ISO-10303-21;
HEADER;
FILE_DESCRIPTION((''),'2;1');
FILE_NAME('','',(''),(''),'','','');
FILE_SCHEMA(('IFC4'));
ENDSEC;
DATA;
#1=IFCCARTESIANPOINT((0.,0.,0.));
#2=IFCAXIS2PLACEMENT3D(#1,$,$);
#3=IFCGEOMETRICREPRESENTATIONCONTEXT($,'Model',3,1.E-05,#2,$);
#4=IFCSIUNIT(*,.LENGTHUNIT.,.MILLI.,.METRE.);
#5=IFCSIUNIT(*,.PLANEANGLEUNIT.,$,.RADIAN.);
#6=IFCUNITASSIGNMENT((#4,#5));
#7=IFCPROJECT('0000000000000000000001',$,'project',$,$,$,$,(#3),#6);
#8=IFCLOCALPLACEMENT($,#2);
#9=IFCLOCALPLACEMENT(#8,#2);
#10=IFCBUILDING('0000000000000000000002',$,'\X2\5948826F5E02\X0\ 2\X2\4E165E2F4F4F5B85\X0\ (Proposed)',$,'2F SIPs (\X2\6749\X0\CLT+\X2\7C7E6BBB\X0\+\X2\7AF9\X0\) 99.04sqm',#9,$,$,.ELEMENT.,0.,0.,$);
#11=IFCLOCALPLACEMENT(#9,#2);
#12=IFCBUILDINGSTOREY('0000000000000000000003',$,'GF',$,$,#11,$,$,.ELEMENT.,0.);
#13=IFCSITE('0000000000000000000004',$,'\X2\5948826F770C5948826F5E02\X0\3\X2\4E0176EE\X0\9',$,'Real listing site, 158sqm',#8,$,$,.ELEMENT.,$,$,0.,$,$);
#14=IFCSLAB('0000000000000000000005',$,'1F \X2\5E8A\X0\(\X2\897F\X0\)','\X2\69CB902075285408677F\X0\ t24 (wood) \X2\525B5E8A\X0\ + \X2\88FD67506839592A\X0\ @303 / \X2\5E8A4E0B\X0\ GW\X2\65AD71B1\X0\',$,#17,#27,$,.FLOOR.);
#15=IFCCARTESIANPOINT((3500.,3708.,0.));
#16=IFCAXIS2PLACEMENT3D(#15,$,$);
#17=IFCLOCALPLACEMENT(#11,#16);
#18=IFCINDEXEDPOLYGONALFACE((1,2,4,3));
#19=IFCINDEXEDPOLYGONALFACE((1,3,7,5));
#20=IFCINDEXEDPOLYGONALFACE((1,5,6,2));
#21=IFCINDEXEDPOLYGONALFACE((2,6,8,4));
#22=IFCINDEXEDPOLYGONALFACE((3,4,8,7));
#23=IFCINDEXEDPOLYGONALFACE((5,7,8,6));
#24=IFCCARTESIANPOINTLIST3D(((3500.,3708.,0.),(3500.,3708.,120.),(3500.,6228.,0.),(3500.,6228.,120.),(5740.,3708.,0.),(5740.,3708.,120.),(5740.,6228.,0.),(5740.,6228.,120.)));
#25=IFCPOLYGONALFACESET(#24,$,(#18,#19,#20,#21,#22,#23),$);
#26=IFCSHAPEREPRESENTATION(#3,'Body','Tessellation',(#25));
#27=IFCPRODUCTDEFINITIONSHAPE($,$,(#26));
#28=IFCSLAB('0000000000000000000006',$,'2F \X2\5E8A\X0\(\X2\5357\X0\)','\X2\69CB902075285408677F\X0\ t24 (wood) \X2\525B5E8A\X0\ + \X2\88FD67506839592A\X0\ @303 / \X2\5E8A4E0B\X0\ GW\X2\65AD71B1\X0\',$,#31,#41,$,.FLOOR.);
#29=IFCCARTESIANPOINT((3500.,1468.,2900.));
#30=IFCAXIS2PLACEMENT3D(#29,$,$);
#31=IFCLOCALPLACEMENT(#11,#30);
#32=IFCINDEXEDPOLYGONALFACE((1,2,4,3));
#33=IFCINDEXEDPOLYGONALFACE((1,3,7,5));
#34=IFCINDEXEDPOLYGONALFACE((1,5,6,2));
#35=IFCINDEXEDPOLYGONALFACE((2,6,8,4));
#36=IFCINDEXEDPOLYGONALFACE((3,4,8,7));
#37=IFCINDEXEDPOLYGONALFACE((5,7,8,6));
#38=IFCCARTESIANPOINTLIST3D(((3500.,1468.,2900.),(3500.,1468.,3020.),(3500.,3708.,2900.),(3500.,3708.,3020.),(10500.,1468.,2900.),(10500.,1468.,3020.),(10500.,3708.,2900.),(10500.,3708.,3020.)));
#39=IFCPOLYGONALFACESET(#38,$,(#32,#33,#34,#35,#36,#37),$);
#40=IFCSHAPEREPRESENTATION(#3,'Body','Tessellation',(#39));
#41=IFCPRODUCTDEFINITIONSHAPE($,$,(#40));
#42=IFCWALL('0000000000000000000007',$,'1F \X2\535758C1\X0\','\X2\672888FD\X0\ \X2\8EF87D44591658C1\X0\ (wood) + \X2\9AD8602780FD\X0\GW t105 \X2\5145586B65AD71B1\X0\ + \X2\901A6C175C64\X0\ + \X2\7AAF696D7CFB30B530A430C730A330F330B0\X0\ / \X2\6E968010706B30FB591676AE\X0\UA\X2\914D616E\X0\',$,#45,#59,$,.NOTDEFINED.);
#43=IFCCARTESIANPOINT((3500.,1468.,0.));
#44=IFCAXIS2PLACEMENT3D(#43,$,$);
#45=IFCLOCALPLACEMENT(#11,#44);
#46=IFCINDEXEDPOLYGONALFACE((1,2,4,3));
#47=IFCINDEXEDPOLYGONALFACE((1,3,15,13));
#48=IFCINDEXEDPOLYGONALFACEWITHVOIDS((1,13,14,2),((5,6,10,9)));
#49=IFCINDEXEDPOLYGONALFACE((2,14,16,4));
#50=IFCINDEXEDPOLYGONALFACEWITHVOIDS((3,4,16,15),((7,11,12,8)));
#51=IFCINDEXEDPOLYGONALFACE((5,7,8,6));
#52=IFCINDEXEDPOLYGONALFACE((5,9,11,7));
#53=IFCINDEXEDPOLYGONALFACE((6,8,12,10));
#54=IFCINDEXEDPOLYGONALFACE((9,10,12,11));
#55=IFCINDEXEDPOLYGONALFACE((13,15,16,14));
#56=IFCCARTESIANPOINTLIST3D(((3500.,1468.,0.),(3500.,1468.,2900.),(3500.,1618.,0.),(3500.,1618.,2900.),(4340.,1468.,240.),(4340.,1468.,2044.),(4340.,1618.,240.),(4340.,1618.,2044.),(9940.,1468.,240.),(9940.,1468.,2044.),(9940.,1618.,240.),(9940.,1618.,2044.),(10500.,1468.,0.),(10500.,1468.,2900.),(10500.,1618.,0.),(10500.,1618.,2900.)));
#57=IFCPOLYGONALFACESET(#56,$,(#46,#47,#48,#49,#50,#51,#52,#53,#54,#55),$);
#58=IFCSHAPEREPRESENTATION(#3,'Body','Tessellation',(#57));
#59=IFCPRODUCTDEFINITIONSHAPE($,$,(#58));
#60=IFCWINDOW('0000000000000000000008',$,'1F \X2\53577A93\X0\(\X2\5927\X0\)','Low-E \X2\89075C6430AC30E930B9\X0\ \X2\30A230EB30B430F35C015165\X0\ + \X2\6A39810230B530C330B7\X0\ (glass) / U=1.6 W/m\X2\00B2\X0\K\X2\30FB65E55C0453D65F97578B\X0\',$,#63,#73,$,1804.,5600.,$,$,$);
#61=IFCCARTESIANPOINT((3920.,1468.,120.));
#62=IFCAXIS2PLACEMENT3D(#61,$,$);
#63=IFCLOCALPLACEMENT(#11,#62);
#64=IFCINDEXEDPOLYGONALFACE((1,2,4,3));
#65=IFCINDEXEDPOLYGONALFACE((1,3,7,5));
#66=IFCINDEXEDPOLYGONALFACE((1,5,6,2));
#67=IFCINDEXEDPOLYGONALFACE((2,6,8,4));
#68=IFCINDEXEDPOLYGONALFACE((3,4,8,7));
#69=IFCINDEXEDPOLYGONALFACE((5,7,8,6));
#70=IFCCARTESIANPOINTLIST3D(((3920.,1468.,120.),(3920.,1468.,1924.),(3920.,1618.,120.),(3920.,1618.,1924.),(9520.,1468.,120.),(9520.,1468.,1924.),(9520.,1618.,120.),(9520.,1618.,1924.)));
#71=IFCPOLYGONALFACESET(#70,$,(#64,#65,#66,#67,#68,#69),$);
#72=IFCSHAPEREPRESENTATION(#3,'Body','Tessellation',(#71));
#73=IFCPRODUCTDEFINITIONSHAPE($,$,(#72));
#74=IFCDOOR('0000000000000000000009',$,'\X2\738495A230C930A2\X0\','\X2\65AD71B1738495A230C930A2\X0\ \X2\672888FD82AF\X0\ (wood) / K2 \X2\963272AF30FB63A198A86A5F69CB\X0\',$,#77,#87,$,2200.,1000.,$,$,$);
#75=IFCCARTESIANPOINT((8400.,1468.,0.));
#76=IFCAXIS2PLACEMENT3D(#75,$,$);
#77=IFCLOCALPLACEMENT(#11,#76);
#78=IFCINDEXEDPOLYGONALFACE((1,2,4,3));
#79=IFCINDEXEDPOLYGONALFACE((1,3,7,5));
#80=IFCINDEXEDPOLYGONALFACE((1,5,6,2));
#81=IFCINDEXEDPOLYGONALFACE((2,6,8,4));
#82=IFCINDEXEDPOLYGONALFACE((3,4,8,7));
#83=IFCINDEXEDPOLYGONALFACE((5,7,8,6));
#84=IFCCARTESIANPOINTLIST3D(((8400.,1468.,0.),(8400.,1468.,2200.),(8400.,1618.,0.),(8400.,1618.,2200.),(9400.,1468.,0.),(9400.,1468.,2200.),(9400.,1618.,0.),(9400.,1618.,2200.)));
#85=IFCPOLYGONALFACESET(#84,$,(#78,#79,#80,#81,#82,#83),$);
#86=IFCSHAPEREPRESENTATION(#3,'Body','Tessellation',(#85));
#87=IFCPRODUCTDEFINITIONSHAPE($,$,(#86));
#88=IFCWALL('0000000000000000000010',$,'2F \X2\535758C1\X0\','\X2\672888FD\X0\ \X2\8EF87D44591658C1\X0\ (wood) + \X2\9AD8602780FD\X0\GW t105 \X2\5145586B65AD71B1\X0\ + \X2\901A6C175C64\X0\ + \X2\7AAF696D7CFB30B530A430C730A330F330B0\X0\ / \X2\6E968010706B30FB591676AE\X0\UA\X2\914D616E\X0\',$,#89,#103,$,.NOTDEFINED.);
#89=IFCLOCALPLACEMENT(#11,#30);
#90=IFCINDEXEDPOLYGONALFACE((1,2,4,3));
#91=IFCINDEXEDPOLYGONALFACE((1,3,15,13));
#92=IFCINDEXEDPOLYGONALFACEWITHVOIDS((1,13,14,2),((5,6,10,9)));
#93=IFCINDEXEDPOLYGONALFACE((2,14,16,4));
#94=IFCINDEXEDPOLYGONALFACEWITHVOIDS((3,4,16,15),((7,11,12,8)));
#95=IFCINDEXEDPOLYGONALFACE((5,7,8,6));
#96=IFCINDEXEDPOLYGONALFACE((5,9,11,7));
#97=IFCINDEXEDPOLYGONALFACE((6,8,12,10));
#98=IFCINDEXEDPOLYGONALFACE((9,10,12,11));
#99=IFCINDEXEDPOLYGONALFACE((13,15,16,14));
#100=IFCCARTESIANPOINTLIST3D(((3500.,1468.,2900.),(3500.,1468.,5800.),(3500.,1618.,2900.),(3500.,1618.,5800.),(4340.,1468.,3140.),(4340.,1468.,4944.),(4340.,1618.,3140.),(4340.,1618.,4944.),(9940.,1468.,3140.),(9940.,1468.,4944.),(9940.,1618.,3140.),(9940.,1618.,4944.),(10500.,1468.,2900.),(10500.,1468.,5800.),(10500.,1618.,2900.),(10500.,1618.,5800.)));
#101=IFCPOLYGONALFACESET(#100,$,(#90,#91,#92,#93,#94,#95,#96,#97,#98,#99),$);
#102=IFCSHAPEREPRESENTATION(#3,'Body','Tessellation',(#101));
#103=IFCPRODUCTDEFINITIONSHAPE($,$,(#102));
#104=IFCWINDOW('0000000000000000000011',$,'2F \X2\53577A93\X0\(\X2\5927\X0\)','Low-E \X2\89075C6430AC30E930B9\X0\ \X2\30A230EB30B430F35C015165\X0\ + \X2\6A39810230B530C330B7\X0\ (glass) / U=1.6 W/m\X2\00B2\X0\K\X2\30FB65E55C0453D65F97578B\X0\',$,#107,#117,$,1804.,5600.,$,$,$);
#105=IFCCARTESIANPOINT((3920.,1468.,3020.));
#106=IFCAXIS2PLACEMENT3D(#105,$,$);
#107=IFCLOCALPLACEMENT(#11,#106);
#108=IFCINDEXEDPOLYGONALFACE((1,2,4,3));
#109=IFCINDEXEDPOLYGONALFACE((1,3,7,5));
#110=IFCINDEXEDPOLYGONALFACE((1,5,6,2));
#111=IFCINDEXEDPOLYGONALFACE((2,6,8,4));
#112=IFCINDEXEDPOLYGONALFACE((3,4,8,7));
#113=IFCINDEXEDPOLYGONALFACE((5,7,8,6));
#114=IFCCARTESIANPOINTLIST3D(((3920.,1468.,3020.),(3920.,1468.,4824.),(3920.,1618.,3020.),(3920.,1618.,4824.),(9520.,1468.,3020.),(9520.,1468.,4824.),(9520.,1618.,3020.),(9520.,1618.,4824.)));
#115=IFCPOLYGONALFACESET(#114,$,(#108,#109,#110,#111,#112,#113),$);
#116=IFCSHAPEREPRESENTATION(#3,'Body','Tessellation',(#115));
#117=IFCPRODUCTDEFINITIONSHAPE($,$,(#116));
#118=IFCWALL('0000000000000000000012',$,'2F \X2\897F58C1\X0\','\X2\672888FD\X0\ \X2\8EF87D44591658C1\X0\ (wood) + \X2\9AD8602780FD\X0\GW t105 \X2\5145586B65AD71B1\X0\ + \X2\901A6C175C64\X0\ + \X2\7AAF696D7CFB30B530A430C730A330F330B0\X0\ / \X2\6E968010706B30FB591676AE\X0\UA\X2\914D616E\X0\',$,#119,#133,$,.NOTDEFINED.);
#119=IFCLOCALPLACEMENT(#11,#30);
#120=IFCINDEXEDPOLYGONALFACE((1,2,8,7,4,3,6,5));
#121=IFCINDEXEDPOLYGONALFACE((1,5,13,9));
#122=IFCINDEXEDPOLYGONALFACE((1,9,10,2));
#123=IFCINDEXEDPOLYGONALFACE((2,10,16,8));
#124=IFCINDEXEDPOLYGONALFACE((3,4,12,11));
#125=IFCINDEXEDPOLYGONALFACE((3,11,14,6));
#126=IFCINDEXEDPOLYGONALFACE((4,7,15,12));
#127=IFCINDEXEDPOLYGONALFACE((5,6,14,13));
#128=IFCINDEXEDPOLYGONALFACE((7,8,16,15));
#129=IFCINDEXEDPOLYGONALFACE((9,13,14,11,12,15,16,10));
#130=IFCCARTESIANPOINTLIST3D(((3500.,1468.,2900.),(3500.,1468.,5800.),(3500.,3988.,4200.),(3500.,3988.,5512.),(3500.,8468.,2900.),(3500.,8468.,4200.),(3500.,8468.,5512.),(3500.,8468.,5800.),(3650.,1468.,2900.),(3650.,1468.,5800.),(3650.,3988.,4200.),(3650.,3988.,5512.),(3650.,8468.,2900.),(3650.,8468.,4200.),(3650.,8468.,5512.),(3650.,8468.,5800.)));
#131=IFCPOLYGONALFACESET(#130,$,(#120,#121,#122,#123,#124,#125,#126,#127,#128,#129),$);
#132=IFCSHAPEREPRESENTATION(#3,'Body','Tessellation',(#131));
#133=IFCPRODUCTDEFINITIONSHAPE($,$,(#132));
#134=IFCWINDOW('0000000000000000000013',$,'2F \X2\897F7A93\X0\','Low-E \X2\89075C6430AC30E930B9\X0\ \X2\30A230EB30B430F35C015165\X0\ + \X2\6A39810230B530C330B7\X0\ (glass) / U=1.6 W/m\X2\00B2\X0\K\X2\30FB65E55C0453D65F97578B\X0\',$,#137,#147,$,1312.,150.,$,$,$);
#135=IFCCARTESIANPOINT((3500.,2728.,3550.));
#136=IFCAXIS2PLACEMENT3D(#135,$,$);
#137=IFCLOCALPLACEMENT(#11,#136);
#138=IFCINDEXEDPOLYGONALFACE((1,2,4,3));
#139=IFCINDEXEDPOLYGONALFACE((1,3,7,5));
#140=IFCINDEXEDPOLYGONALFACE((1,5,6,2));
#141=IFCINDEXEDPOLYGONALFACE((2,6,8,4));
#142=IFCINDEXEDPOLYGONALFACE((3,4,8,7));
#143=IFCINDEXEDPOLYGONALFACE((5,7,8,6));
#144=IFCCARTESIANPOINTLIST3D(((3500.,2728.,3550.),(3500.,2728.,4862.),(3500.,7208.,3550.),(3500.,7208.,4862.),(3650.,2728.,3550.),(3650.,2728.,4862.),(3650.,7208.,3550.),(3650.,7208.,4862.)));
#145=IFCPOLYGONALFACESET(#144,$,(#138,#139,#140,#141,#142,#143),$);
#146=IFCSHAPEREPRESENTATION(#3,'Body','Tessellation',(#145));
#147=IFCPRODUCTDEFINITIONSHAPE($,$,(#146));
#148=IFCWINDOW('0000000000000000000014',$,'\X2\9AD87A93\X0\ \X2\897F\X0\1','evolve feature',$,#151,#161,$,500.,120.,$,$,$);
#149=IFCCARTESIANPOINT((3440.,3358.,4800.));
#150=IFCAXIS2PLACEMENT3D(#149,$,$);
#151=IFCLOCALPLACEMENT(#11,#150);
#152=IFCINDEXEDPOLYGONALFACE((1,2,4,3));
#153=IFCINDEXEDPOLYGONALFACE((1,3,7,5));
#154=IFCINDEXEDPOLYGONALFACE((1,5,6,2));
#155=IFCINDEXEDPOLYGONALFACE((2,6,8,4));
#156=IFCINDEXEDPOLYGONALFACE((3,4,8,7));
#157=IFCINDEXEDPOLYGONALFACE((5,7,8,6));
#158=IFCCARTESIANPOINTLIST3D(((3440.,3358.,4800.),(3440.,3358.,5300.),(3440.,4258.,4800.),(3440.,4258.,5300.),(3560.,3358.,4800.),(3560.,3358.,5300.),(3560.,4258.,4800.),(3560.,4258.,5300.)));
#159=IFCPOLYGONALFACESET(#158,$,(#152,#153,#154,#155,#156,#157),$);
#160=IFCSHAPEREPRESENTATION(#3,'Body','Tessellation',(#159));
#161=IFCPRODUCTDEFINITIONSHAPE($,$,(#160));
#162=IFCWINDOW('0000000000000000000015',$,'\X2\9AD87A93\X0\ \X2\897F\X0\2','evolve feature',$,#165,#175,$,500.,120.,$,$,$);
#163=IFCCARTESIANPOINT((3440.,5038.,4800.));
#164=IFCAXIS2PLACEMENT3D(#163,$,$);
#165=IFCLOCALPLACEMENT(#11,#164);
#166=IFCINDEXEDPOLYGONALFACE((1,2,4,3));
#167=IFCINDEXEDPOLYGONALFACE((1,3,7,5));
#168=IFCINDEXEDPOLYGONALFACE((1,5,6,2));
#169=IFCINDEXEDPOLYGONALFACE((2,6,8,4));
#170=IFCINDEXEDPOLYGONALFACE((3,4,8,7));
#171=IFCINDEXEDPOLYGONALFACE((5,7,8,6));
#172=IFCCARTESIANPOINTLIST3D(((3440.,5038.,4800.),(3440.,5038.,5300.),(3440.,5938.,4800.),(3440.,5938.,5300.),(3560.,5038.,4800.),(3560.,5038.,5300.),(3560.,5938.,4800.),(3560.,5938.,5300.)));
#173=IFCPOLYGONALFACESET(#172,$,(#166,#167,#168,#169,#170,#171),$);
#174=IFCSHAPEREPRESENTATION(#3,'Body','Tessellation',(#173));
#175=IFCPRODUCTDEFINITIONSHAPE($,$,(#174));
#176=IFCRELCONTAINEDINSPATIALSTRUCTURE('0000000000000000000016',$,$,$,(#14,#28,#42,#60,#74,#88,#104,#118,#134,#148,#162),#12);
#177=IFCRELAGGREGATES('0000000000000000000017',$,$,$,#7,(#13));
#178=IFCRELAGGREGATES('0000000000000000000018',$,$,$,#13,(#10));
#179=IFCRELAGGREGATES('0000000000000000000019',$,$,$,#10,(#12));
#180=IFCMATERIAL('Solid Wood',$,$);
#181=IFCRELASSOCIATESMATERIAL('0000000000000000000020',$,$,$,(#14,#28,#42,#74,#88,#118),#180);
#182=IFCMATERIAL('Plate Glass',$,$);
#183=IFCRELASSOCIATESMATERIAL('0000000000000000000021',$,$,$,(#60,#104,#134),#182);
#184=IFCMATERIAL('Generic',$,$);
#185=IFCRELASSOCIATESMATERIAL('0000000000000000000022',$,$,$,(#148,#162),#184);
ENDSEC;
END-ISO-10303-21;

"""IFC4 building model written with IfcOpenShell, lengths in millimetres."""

from ifc_helpers import new_model, si_unit, frame, frame_2d, origin, place, context, project, spatial, rectangle, extrude, material, element, fill, save


model = new_model("IFC4")

# Units and contexts
model_context = context("Model", 3, precision=1e-05, world=origin())
ifc_project = project(units=[si_unit("LENGTHUNIT", "METRE", prefix="MILLI"), si_unit("PLANEANGLEUNIT", "RADIAN")], contexts=[model_context])

# Site, building, storey
site_placement = place(None, origin())
site = spatial("IfcSite", under=ifc_project, at=site_placement, Name="奈良県奈良市3丁目9", ObjectType="Real listing site, 158sqm", CompositionType="ELEMENT", RefElevation=0.0)
building_placement = place(site_placement, origin())
building = spatial("IfcBuilding", under=site, at=building_placement, Name="奈良市 2世帯住宅 (Proposed)", ObjectType="2F SIPs (杉CLT+籾殻+竹) 99.04sqm", CompositionType="ELEMENT", ElevationOfRefHeight=0.0, ElevationOfTerrain=0.0)
storey_placement = place(building_placement, origin())
storey = spatial("IfcBuildingStorey", under=building, at=storey_placement, Name="GF", CompositionType="ELEMENT", Elevation=0.0)

# Slabs
ifc_material_1 = material(Name="Solid Wood")
slab_1_placement = place(storey_placement, frame((3500.0, 3708.0, 0.0)))
element("IfcSlab", 1, at=slab_1_placement, inside=storey, material=ifc_material_1, Name="1F 床(西)", Description="構造用合板 t24 (wood) 剛床 + 製材根太 @303 / 床下 GW断熱", PredefinedType="FLOOR", context=model_context, shape_type="SweptSolid", body=[
    extrude(rectangle(XDim=2240.0, YDim=2520.0, at=frame_2d((1120.0, 1260.0))), frame((3500.0, 3708.0, 0.0)), (0.0, 0.0, 1.0), 120.0),
])
slab_2_placement = place(storey_placement, frame((3500.0, 1468.0, 2900.0)))
element("IfcSlab", 2, at=slab_2_placement, inside=storey, material=ifc_material_1, Name="2F 床(南)", Description="構造用合板 t24 (wood) 剛床 + 製材根太 @303 / 床下 GW断熱", PredefinedType="FLOOR", context=model_context, shape_type="SweptSolid", body=[
    extrude(rectangle(XDim=7000.0, YDim=2240.0, at=frame_2d((3500.0, 1120.0))), frame((3500.0, 1468.0, 2900.0)), (0.0, 0.0, 1.0), 120.0),
])
ifc_material_2 = material(Name="Generic")

# Wall, openings, window, door
wall_1_placement = place(storey_placement, frame((3500.0, 1468.0, 0.0)))
wall_1 = element("IfcWall", 3, at=wall_1_placement, inside=storey, material=ifc_material_1, Name="1F 南壁", Description="木製 軸組外壁 (wood) + 高性能GW t105 充填断熱 + 通気層 + 窯業系サイディング / 準耐火・外皮UA配慮", PredefinedType="NOTDEFINED", context=model_context, shape_type="SweptSolid", body=[
    extrude(rectangle(XDim=7000.0, YDim=150.0, at=frame_2d((3500.0, 75.0))), frame((3500.0, 1468.0, 0.0)), (0.0, 0.0, 1.0), 2900.0),
])
opening_1_placement = place(storey_placement, frame((3920.0, 1468.0, 120.0)))
opening_1 = element("IfcOpeningElement", 4, at=opening_1_placement, cuts=wall_1, PredefinedType="NOTDEFINED", context=model_context, shape_type="SweptSolid", body=[
    extrude(rectangle(XDim=5600.0, YDim=150.0, at=frame_2d((2800.0, 75.0))), frame((3920.0, 1468.0, 120.0)), (0.0, 0.0, 1.0), 1804.0),
])
opening_2_placement = place(storey_placement, frame((8400.0, 1468.0, 0.0)))
opening_2 = element("IfcOpeningElement", 5, at=opening_2_placement, cuts=wall_1, PredefinedType="NOTDEFINED", context=model_context, shape_type="SweptSolid", body=[
    extrude(rectangle(XDim=1000.0, YDim=150.0, at=frame_2d((500.0, 75.0))), frame((8400.0, 1468.0, 0.0)), (0.0, 0.0, 1.0), 2200.0),
])
ifc_material_3 = material(Name="Plate Glass")
window_1_placement = place(storey_placement, frame((3920.0, 1468.0, 120.0)))
window_1 = element("IfcWindow", 6, at=window_1_placement, inside=storey, material=ifc_material_3, Name="1F 南窓(大)", Description="Low-E 複層ガラス アルゴン封入 + 樹脂サッシ (glass) / U=1.6 W/m²K・日射取得型", OverallHeight=1804.0, OverallWidth=5600.0, context=model_context, shape_type="SweptSolid", body=[
    extrude(rectangle(XDim=5600.0, YDim=150.0, at=frame_2d((2800.0, 75.0))), frame((3920.0, 1468.0, 120.0)), (0.0, 0.0, 1.0), 1804.0),
])
fill(opening_1, window_1)
door_placement = place(storey_placement, frame((8400.0, 1468.0, 0.0)))
door = element("IfcDoor", 7, at=door_placement, inside=storey, material=ifc_material_1, Name="玄関ドア", Description="断熱玄関ドア 木製芯 (wood) / K2 防犯・採風機構", OverallHeight=2200.0, OverallWidth=1000.0, context=model_context, shape_type="SweptSolid", body=[
    extrude(rectangle(XDim=1000.0, YDim=150.0, at=frame_2d((500.0, 75.0))), frame((8400.0, 1468.0, 0.0)), (0.0, 0.0, 1.0), 2200.0),
])
fill(opening_2, door)

# Wall, opening, window
wall_2_placement = place(storey_placement, frame((3500.0, 1468.0, 2900.0)))
wall_2 = element("IfcWall", 8, at=wall_2_placement, inside=storey, material=ifc_material_1, Name="2F 南壁", Description="木製 軸組外壁 (wood) + 高性能GW t105 充填断熱 + 通気層 + 窯業系サイディング / 準耐火・外皮UA配慮", PredefinedType="NOTDEFINED", context=model_context, shape_type="SweptSolid", body=[
    extrude(rectangle(XDim=7000.0, YDim=150.0, at=frame_2d((3500.0, 75.0))), frame((3500.0, 1468.0, 2900.0)), (0.0, 0.0, 1.0), 2900.0),
])
opening_3_placement = place(storey_placement, frame((3920.0, 1468.0, 3020.0)))
opening_3 = element("IfcOpeningElement", 9, at=opening_3_placement, cuts=wall_2, PredefinedType="NOTDEFINED", context=model_context, shape_type="SweptSolid", body=[
    extrude(rectangle(XDim=5600.0, YDim=150.0, at=frame_2d((2800.0, 75.0))), frame((3920.0, 1468.0, 3020.0)), (0.0, 0.0, 1.0), 1804.0),
])
window_2_placement = place(storey_placement, frame((3920.0, 1468.0, 3020.0)))
window_2 = element("IfcWindow", 10, at=window_2_placement, inside=storey, material=ifc_material_3, Name="2F 南窓(大)", Description="Low-E 複層ガラス アルゴン封入 + 樹脂サッシ (glass) / U=1.6 W/m²K・日射取得型", OverallHeight=1804.0, OverallWidth=5600.0, context=model_context, shape_type="SweptSolid", body=[
    extrude(rectangle(XDim=5600.0, YDim=150.0, at=frame_2d((2800.0, 75.0))), frame((3920.0, 1468.0, 3020.0)), (0.0, 0.0, 1.0), 1804.0),
])
fill(opening_3, window_2)

# Wall, openings, windows
wall_3_placement = place(storey_placement, frame((3500.0, 1468.0, 2900.0)))
wall_3 = element("IfcWall", 11, at=wall_3_placement, inside=storey, material=ifc_material_1, Name="2F 西壁", Description="木製 軸組外壁 (wood) + 高性能GW t105 充填断熱 + 通気層 + 窯業系サイディング / 準耐火・外皮UA配慮", PredefinedType="NOTDEFINED", context=model_context, shape_type="SweptSolid", body=[
    extrude(rectangle(XDim=150.0, YDim=7000.0, at=frame_2d((75.0, 3500.0))), frame((3500.0, 1468.0, 2900.0)), (0.0, 0.0, 1.0), 2900.0),
])
opening_4_placement = place(storey_placement, frame((3500.0, 2728.0, 3550.0)))
opening_4 = element("IfcOpeningElement", 12, at=opening_4_placement, cuts=wall_3, PredefinedType="NOTDEFINED", context=model_context, shape_type="SweptSolid", body=[
    extrude(rectangle(XDim=150.0, YDim=4480.0, at=frame_2d((75.0, 2240.0))), frame((3500.0, 2728.0, 3550.0)), (0.0, 0.0, 1.0), 1312.0),
])
opening_5_placement = place(storey_placement, frame((3440.0, 3358.0, 4800.0)))
opening_5 = element("IfcOpeningElement", 13, at=opening_5_placement, cuts=wall_3, PredefinedType="NOTDEFINED", context=model_context, shape_type="SweptSolid", body=[
    extrude(rectangle(XDim=120.0, YDim=900.0, at=frame_2d((60.0, 450.0))), frame((3440.0, 3358.0, 4800.0)), (0.0, 0.0, 1.0), 500.0),
])
opening_6_placement = place(storey_placement, frame((3440.0, 5038.0, 4800.0)))
opening_6 = element("IfcOpeningElement", 14, at=opening_6_placement, cuts=wall_3, PredefinedType="NOTDEFINED", context=model_context, shape_type="SweptSolid", body=[
    extrude(rectangle(XDim=120.0, YDim=900.0, at=frame_2d((60.0, 450.0))), frame((3440.0, 5038.0, 4800.0)), (0.0, 0.0, 1.0), 500.0),
])
window_3_placement = place(storey_placement, frame((3500.0, 2728.0, 3550.0)))
window_3 = element("IfcWindow", 15, at=window_3_placement, inside=storey, material=ifc_material_3, Name="2F 西窓", Description="Low-E 複層ガラス アルゴン封入 + 樹脂サッシ (glass) / U=1.6 W/m²K・日射取得型", OverallHeight=1312.0, OverallWidth=150.0, context=model_context, shape_type="SweptSolid", body=[
    extrude(rectangle(XDim=150.0, YDim=4480.0, at=frame_2d((75.0, 2240.0))), frame((3500.0, 2728.0, 3550.0)), (0.0, 0.0, 1.0), 1312.0),
])
fill(opening_4, window_3)
window_4_placement = place(storey_placement, frame((3440.0, 3358.0, 4800.0)))
window_4 = element("IfcWindow", 16, at=window_4_placement, inside=storey, material=ifc_material_2, Name="高窓 西1", Description="evolve feature", OverallHeight=500.0, OverallWidth=120.0, context=model_context, shape_type="SweptSolid", body=[
    extrude(rectangle(XDim=120.0, YDim=900.0, at=frame_2d((60.0, 450.0))), frame((3440.0, 3358.0, 4800.0)), (0.0, 0.0, 1.0), 500.0),
])
fill(opening_5, window_4)
window_5_placement = place(storey_placement, frame((3440.0, 5038.0, 4800.0)))
window_5 = element("IfcWindow", 17, at=window_5_placement, inside=storey, material=ifc_material_2, Name="高窓 西2", Description="evolve feature", OverallHeight=500.0, OverallWidth=120.0, context=model_context, shape_type="SweptSolid", body=[
    extrude(rectangle(XDim=120.0, YDim=900.0, at=frame_2d((60.0, 450.0))), frame((3440.0, 5038.0, 4800.0)), (0.0, 0.0, 1.0), 500.0),
])
fill(opening_6, window_5)

save(model, "model.ifc")
